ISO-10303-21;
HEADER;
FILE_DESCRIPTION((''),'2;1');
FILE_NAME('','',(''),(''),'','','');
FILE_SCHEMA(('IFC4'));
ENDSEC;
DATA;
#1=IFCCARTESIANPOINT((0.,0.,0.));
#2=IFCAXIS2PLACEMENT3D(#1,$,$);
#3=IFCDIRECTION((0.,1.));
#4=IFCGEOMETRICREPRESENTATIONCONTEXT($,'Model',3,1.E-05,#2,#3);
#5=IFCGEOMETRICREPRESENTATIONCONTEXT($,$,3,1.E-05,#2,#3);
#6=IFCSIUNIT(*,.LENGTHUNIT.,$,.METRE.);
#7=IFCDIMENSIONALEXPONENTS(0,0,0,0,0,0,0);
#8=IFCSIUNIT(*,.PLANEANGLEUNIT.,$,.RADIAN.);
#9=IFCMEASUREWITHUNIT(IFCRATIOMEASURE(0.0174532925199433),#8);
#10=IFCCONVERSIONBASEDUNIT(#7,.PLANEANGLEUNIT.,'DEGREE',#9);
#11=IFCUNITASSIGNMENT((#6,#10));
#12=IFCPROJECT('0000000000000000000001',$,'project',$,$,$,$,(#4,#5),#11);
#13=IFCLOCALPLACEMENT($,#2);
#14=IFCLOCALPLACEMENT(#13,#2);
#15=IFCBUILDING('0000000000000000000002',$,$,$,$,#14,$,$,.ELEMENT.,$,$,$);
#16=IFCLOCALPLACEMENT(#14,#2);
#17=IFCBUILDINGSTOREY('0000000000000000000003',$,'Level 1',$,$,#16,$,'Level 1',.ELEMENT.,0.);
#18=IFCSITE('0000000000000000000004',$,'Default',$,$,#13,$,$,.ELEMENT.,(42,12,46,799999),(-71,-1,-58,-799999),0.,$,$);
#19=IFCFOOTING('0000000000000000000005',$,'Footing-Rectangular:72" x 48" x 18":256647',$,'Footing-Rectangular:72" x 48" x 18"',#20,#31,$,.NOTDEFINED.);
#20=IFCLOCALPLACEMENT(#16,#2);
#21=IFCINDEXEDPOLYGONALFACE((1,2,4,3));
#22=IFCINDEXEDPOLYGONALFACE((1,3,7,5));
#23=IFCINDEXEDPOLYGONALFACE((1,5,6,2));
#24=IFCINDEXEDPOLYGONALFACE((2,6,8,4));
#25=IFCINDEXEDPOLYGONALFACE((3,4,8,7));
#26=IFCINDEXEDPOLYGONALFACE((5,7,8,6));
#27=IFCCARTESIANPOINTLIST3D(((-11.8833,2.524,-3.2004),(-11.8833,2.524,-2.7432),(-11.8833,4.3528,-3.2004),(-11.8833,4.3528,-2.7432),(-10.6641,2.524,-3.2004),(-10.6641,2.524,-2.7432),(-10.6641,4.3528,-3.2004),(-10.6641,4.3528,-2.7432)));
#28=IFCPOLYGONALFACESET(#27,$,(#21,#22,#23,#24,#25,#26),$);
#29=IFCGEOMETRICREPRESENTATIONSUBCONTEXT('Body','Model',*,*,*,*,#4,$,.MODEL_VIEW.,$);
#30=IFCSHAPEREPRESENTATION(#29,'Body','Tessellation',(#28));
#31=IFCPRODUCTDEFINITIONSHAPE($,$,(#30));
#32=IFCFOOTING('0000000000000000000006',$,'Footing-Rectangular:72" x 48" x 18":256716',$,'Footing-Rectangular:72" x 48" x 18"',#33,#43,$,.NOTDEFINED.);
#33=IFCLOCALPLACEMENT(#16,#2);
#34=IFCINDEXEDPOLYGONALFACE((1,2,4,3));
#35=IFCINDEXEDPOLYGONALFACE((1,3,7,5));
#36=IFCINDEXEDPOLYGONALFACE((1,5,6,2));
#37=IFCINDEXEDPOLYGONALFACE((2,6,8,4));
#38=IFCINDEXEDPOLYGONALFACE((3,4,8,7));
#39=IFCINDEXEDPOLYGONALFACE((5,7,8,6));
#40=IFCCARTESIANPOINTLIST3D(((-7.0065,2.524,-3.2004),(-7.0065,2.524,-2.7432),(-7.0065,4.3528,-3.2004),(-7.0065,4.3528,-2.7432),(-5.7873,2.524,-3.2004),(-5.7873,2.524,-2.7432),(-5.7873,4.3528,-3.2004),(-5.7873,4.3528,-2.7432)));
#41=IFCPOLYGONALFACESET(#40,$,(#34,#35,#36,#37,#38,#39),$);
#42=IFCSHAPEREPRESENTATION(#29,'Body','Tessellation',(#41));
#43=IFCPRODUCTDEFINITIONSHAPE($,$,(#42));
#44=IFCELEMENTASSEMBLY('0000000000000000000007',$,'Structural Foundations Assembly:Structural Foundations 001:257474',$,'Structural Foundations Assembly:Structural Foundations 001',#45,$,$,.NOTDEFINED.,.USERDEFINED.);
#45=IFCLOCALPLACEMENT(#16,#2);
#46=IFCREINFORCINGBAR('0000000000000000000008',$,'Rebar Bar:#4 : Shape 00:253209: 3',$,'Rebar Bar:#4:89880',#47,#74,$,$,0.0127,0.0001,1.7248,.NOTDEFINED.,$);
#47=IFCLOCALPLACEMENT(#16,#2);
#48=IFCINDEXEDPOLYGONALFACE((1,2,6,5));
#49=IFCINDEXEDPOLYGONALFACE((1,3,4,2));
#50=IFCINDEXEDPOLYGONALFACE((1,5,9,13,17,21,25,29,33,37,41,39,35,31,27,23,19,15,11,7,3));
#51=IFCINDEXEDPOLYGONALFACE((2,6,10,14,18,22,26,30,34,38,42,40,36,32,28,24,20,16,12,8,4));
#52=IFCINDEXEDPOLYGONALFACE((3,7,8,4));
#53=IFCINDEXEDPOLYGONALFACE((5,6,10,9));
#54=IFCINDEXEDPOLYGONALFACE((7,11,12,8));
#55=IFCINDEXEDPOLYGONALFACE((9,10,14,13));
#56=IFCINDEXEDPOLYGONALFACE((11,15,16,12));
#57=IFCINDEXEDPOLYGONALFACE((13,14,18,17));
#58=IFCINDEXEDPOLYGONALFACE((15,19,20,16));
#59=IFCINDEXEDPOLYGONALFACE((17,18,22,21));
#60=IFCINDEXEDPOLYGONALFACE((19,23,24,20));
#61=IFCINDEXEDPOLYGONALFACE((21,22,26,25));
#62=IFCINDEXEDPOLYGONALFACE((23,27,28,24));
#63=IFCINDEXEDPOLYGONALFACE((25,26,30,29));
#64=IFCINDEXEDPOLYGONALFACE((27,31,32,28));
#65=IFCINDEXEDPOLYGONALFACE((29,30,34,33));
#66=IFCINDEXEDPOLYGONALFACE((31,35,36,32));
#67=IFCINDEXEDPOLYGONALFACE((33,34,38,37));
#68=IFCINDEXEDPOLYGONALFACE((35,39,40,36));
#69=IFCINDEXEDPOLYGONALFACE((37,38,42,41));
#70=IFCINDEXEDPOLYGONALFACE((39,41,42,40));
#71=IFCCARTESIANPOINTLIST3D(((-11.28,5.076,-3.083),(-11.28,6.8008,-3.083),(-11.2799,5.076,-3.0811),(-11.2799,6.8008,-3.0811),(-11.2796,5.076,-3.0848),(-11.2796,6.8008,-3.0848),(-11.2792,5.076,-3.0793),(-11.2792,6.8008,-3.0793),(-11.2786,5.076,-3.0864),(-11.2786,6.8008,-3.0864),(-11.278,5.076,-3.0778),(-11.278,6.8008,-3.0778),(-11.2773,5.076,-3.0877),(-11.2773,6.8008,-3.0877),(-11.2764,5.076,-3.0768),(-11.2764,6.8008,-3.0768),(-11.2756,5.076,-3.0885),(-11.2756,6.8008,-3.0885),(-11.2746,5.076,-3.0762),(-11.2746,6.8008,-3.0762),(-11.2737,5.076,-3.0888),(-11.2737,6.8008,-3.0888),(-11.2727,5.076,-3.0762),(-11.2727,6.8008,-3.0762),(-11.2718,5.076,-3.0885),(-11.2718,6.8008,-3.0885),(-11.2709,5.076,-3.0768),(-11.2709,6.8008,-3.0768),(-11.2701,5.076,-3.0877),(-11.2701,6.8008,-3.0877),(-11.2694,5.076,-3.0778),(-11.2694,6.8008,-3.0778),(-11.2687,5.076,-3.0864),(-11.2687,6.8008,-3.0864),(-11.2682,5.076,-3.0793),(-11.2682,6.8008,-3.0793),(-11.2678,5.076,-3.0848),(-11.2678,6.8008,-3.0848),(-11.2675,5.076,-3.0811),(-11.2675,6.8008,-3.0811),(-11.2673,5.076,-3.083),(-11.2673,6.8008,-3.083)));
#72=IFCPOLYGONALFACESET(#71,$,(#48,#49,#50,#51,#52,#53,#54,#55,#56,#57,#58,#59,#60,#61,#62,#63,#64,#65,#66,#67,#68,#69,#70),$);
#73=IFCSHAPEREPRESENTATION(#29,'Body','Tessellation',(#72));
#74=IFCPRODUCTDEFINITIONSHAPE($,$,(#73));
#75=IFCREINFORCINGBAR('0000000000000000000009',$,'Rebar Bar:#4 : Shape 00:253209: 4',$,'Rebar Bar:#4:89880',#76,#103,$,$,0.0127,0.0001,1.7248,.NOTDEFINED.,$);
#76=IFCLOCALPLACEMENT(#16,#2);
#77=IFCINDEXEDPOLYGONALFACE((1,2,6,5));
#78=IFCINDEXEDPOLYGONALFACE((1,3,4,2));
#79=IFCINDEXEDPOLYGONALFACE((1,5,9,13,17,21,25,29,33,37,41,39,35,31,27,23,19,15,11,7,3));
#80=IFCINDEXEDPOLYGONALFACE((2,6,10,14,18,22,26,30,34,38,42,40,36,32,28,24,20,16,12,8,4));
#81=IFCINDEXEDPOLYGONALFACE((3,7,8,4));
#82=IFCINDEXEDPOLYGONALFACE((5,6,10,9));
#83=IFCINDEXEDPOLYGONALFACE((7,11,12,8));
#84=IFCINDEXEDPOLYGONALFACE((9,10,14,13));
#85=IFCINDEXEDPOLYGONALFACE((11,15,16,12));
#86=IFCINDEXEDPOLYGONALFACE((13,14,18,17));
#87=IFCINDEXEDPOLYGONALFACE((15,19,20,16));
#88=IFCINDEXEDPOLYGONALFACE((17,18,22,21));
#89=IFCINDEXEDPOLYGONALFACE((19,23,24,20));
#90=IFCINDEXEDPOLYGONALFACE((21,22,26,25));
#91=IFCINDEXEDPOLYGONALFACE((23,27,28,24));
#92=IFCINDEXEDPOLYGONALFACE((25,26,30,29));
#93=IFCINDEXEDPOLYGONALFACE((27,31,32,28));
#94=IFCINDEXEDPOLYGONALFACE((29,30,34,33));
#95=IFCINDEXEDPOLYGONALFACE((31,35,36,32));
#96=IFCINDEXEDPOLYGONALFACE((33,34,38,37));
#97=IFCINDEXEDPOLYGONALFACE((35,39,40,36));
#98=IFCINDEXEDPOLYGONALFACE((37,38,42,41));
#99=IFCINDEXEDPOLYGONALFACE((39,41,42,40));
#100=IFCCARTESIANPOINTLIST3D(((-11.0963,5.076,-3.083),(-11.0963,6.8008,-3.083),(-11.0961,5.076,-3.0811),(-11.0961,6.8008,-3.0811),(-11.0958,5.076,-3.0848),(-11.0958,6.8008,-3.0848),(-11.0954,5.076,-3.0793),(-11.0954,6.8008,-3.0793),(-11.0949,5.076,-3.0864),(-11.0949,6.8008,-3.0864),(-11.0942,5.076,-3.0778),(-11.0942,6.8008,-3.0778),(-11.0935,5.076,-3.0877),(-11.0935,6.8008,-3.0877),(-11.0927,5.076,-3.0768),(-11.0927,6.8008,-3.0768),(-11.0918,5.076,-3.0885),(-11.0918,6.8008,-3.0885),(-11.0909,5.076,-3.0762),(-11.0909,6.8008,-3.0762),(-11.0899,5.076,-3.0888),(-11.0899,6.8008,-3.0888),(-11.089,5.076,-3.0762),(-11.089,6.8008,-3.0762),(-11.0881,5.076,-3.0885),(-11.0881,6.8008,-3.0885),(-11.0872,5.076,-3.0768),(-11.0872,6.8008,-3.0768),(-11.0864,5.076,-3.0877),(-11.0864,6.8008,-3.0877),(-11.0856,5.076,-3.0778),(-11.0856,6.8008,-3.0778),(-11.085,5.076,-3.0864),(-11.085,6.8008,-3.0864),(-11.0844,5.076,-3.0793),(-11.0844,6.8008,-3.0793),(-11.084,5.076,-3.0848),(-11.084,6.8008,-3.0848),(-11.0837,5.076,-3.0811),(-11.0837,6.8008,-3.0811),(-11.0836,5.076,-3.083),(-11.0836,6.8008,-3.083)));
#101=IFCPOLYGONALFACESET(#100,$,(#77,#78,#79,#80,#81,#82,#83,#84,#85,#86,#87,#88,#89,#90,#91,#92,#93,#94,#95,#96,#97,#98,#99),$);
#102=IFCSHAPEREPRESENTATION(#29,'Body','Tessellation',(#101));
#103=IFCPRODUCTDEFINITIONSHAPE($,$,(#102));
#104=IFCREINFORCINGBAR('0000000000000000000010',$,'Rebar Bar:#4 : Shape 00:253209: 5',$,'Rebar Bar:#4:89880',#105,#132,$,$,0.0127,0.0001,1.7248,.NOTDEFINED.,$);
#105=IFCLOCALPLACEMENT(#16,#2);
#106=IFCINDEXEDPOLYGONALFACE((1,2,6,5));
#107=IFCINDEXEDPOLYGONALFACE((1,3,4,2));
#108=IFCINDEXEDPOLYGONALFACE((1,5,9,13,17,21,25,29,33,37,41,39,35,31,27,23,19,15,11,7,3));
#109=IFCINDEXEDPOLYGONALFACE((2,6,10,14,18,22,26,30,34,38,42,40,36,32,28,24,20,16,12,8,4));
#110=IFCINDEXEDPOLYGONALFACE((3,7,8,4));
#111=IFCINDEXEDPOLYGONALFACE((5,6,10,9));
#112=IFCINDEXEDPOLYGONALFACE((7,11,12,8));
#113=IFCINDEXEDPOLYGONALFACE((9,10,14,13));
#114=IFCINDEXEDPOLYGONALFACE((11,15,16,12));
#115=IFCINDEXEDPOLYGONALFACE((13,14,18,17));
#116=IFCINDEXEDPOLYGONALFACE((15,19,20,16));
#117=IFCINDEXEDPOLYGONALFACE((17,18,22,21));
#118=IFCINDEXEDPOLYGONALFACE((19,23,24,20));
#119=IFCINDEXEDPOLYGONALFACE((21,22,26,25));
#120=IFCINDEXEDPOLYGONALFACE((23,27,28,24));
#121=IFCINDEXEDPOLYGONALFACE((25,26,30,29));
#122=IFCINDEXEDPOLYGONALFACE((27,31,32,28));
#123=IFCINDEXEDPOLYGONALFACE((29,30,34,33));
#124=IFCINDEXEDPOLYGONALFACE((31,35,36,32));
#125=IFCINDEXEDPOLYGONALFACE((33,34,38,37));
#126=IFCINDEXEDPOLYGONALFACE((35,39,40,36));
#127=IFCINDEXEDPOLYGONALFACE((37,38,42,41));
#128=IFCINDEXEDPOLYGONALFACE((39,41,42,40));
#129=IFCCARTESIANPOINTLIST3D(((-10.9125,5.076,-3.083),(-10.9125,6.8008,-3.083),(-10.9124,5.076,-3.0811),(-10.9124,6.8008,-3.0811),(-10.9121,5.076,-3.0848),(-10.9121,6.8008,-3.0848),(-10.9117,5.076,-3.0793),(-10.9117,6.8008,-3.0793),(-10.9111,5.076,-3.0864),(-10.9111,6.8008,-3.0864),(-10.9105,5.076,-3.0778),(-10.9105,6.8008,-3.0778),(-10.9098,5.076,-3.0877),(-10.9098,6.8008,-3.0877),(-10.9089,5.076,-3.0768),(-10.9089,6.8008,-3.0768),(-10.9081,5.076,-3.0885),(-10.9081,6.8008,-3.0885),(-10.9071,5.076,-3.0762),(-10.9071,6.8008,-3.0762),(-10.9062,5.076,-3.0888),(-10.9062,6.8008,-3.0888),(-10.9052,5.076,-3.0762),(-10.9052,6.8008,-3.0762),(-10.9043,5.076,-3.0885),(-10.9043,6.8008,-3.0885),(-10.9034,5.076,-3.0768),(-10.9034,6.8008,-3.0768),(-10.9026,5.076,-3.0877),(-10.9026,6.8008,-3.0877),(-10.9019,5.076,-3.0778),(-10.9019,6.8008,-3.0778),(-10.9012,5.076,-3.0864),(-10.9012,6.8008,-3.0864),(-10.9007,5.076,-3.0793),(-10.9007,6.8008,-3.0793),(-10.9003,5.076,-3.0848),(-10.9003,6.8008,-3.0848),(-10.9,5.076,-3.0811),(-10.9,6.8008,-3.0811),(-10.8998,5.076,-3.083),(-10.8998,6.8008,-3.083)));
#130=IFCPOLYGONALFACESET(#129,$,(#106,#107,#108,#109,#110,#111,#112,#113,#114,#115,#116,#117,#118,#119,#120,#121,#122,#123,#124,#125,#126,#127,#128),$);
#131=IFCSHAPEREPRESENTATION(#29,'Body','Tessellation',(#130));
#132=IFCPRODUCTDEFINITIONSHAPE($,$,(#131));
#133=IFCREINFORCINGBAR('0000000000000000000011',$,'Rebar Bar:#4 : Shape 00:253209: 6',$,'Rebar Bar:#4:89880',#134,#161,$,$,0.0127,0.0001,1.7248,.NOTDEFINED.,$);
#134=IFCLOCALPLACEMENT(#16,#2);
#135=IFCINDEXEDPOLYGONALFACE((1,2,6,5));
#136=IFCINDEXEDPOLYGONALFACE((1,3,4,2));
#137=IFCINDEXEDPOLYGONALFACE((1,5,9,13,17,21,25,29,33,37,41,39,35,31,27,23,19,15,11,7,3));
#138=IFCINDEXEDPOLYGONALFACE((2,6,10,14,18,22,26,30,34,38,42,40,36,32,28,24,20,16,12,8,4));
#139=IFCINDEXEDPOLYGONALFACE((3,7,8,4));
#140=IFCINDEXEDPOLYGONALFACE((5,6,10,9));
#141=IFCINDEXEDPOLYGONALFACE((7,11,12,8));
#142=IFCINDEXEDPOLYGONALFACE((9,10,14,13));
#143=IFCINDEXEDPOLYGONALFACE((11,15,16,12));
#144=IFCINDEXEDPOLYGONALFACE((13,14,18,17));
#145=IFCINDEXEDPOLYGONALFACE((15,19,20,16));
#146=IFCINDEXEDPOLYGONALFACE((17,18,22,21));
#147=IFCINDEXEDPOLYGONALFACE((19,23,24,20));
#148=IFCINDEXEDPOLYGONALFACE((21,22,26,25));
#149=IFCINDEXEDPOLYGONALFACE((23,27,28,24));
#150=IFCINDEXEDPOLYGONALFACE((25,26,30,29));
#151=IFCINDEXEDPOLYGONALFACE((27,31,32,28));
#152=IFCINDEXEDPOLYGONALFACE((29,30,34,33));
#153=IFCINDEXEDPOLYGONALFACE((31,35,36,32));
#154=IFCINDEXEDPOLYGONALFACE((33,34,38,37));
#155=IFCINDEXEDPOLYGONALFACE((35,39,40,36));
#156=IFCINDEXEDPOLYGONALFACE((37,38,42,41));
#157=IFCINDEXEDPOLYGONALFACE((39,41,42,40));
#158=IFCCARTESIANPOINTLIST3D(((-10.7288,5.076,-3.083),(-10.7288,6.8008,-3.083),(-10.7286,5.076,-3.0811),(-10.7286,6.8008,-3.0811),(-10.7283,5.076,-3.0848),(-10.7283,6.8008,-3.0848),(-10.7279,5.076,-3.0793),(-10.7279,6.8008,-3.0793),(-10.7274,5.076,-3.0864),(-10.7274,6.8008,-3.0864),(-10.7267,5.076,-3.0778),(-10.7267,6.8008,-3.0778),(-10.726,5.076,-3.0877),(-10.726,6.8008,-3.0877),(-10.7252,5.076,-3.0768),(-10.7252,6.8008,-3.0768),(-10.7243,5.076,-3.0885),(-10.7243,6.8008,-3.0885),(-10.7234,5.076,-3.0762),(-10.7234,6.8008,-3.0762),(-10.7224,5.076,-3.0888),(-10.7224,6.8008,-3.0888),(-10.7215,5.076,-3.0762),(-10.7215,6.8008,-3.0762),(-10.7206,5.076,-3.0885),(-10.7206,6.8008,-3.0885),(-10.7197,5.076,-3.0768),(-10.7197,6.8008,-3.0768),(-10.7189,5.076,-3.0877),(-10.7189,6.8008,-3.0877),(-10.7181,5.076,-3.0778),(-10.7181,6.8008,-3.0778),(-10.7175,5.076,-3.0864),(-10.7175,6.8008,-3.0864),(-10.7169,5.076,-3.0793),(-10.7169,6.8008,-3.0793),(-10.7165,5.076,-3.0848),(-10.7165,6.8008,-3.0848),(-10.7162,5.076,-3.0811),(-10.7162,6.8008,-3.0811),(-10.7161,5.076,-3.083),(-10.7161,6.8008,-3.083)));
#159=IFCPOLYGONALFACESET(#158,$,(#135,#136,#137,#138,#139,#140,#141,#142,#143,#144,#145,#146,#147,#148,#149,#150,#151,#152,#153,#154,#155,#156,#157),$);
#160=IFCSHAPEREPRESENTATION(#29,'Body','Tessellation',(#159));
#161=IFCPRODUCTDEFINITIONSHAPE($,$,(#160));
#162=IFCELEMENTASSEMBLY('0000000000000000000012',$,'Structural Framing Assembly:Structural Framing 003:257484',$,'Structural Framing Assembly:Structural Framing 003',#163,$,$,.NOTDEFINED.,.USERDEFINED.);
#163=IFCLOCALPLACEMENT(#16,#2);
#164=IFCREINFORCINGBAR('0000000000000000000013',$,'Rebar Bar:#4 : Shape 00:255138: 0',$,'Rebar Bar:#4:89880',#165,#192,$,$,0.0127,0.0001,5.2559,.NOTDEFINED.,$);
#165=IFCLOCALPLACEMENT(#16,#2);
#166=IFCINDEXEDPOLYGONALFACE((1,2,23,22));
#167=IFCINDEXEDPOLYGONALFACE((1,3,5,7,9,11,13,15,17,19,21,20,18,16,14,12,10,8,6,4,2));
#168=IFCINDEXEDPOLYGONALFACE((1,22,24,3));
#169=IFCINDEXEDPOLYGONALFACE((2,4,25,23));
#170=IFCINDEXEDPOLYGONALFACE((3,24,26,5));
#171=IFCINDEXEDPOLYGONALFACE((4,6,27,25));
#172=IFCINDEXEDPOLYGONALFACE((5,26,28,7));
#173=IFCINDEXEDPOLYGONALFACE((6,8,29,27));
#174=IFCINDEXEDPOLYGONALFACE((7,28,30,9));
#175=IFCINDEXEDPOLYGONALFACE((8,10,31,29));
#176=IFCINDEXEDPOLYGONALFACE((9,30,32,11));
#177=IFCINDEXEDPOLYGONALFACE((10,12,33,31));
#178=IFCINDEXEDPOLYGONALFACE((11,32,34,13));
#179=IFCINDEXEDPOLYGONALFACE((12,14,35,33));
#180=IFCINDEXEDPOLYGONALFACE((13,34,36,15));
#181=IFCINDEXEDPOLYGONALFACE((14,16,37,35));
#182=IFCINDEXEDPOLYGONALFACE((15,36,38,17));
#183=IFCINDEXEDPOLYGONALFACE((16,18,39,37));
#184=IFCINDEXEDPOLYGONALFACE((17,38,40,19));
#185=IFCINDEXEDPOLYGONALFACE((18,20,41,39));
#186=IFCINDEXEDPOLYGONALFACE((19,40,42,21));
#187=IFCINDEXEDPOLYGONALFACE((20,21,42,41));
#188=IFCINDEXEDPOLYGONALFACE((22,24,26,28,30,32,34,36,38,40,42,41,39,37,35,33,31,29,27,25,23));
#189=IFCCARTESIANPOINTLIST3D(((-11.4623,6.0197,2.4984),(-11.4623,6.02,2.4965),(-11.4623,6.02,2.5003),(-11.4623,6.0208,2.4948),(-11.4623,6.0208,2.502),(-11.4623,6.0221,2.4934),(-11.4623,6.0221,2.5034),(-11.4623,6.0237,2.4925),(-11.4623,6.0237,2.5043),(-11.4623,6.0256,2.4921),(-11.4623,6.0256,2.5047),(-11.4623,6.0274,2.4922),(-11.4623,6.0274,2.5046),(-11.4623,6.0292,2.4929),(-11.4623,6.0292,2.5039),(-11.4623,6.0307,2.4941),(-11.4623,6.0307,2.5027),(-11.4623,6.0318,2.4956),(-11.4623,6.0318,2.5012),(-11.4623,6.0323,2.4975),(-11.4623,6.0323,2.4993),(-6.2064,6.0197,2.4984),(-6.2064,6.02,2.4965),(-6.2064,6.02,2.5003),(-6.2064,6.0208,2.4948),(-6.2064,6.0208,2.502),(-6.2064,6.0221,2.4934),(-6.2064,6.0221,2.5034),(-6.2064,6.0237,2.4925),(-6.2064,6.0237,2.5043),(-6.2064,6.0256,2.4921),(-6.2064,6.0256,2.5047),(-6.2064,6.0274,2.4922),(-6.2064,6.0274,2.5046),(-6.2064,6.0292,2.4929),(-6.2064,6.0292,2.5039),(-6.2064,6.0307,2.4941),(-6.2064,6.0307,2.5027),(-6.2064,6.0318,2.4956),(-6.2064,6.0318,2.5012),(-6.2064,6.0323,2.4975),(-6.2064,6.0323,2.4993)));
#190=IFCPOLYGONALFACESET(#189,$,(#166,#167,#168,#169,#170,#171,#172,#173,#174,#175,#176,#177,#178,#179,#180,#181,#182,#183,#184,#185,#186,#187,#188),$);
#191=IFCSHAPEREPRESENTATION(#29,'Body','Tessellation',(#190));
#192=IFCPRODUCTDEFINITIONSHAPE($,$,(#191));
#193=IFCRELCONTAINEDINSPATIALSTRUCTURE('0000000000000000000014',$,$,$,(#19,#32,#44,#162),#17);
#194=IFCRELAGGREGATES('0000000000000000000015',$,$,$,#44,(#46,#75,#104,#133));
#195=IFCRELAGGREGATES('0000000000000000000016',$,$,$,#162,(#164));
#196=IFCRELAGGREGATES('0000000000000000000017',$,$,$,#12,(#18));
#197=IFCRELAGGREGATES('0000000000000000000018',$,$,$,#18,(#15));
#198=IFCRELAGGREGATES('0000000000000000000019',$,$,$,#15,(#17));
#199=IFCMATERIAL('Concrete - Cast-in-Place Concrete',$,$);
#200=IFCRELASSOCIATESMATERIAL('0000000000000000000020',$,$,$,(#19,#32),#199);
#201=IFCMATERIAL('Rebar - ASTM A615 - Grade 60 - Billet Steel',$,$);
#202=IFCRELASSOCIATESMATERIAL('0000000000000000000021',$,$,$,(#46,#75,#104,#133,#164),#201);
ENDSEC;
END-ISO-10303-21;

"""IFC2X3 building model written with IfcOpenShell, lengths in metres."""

from ifc_helpers import new_model, entity, si_unit, converted_unit, direction, frame, frame_2d, origin, origin_2d_with_axis, place, context, subcontext, project, spatial, rectangle, extrude, material, element, aggregate, save


model = new_model("IFC2X3")

# Units and contexts
model_context = context("Model", 3, precision=1e-05, world=origin(), true_north=direction((0.0, 1.0)))
context_of_model = context(None, 3, precision=1e-05, world=origin(), true_north=direction((0.0, 1.0)))
body_context = subcontext(model_context, "Body", "Model", "MODEL_VIEW")
ifc_project = project(units=[si_unit("LENGTHUNIT", "METRE"), converted_unit("PLANEANGLEUNIT", "DEGREE", entity("IfcRatioMeasure", 0.0174532925199433), si_unit("PLANEANGLEUNIT", "RADIAN"), dimensions=[0, 0, 0, 0, 0, 0, 0])], contexts=[model_context, context_of_model])

# Site, building, storey
site_placement = place(None, origin())
site = spatial("IfcSite", under=ifc_project, at=site_placement, Name="Default", CompositionType="ELEMENT", RefLatitude=(42, 12, 46, 799999), RefLongitude=(-71, -1, -58, -799999), RefElevation=0.0)
building_placement = place(site_placement, origin())
building = spatial("IfcBuilding", under=site, at=building_placement, CompositionType="ELEMENT")
storey_placement = place(building_placement, origin())
storey = spatial("IfcBuildingStorey", under=building, at=storey_placement, Name="Level 1", LongName="Level 1", CompositionType="ELEMENT", Elevation=0.0)

# Footings
ifc_material_1 = material(Name="Concrete - Cast-in-Place Concrete")
footing_1_placement = place(storey_placement, origin())
element("IfcFooting", 1, at=footing_1_placement, inside=storey, material=ifc_material_1, Name="Footing-Rectangular:72\" x 48\" x 18\":256647", ObjectType="Footing-Rectangular:72\" x 48\" x 18\"", PredefinedType="NOTDEFINED", context=body_context, shape_type="SweptSolid", body=[
    extrude(rectangle(XDim=1.2192, YDim=1.8288, at=origin_2d_with_axis()), frame((-11.2737, 3.4384, -3.2004), z_axis=(0.0, 0.0, 1.0), x_axis=(-1.0, 0.0, 0.0)), (0.0, 0.0, 1.0), 0.4572),
])
footing_2_placement = place(storey_placement, origin())
element("IfcFooting", 2, at=footing_2_placement, inside=storey, material=ifc_material_1, Name="Footing-Rectangular:72\" x 48\" x 18\":256716", ObjectType="Footing-Rectangular:72\" x 48\" x 18\"", PredefinedType="NOTDEFINED", context=body_context, shape_type="SweptSolid", body=[
    extrude(rectangle(XDim=1.2192, YDim=1.8288, at=frame_2d((0.0, 0.0), x_axis=(1.0, 0.0))), frame((-6.3969, 3.4384, -3.2004), z_axis=(0.0, 0.0, 1.0), x_axis=(-1.0, 0.0, 0.0)), (0.0, 0.0, 1.0), 0.4572),
])

# Element assemblies, reinforcing bars
assembly_1_placement = place(storey_placement, origin())
assembly_1 = element("IfcElementAssembly", 3, at=assembly_1_placement, inside=storey, Name="Structural Foundations Assembly:Structural Foundations 001:257474", ObjectType="Structural Foundations Assembly:Structural Foundations 001", AssemblyPlace="NOTDEFINED", PredefinedType="USERDEFINED")
ifc_material_2 = material(Name="Rebar - ASTM A615 - Grade 60 - Billet Steel")
reinforcing_bar_1_placement = place(assembly_1_placement, origin())
reinforcing_bar_1 = element("IfcReinforcingBar", 4, at=reinforcing_bar_1_placement, material=ifc_material_2, Name="Rebar Bar:#4 : Shape 00:253209: 3", ObjectType="Rebar Bar:#4:89880", BarLength=1.7248, BarRole="NOTDEFINED", CrossSectionArea=0.0001, NominalDiameter=0.0127, context=body_context, shape_type="AdvancedSweptSolid", body=[
    entity("IfcSweptDiskSolid", entity("IfcCompositeCurve", [entity("IfcCompositeCurveSegment", "CONTINUOUS", True, entity("IfcPolyline", [entity("IfcCartesianPoint", [-11.2737, 6.8008, -3.0825]), entity("IfcCartesianPoint", [-11.2737, 5.076, -3.0825])]))], False), 0.0063, None, 0.0, 1.0),
])
reinforcing_bar_2_placement = place(assembly_1_placement, origin())
reinforcing_bar_2 = element("IfcReinforcingBar", 5, at=reinforcing_bar_2_placement, material=ifc_material_2, Name="Rebar Bar:#4 : Shape 00:253209: 4", ObjectType="Rebar Bar:#4:89880", BarLength=1.7248, BarRole="NOTDEFINED", CrossSectionArea=0.0001, NominalDiameter=0.0127, context=body_context, shape_type="AdvancedSweptSolid", body=[
    entity("IfcSweptDiskSolid", entity("IfcCompositeCurve", [entity("IfcCompositeCurveSegment", "CONTINUOUS", True, entity("IfcPolyline", [entity("IfcCartesianPoint", [-11.0899, 6.8008, -3.0825]), entity("IfcCartesianPoint", [-11.0899, 5.076, -3.0825])]))], False), 0.0063, None, 0.0, 1.0),
])
reinforcing_bar_3_placement = place(assembly_1_placement, origin())
reinforcing_bar_3 = element("IfcReinforcingBar", 6, at=reinforcing_bar_3_placement, material=ifc_material_2, Name="Rebar Bar:#4 : Shape 00:253209: 5", ObjectType="Rebar Bar:#4:89880", BarLength=1.7248, BarRole="NOTDEFINED", CrossSectionArea=0.0001, NominalDiameter=0.0127, context=body_context, shape_type="AdvancedSweptSolid", body=[
    entity("IfcSweptDiskSolid", entity("IfcCompositeCurve", [entity("IfcCompositeCurveSegment", "CONTINUOUS", True, entity("IfcPolyline", [entity("IfcCartesianPoint", [-10.9062, 6.8008, -3.0825]), entity("IfcCartesianPoint", [-10.9062, 5.076, -3.0825])]))], False), 0.0063, None, 0.0, 1.0),
])
reinforcing_bar_4_placement = place(assembly_1_placement, origin())
reinforcing_bar_4 = element("IfcReinforcingBar", 7, at=reinforcing_bar_4_placement, material=ifc_material_2, Name="Rebar Bar:#4 : Shape 00:253209: 6", ObjectType="Rebar Bar:#4:89880", BarLength=1.7248, BarRole="NOTDEFINED", CrossSectionArea=0.0001, NominalDiameter=0.0127, context=body_context, shape_type="AdvancedSweptSolid", body=[
    entity("IfcSweptDiskSolid", entity("IfcCompositeCurve", [entity("IfcCompositeCurveSegment", "CONTINUOUS", True, entity("IfcPolyline", [entity("IfcCartesianPoint", [-10.7224, 6.8008, -3.0825]), entity("IfcCartesianPoint", [-10.7224, 5.076, -3.0825])]))], False), 0.0063, None, 0.0, 1.0),
])
aggregate(assembly_1, [reinforcing_bar_1, reinforcing_bar_2, reinforcing_bar_3, reinforcing_bar_4])
assembly_2_placement = place(storey_placement, origin())
assembly_2 = element("IfcElementAssembly", 8, at=assembly_2_placement, inside=storey, Name="Structural Framing Assembly:Structural Framing 003:257484", ObjectType="Structural Framing Assembly:Structural Framing 003", AssemblyPlace="NOTDEFINED", PredefinedType="USERDEFINED")
reinforcing_bar_5_placement = place(assembly_2_placement, origin())
reinforcing_bar_5 = element("IfcReinforcingBar", 9, at=reinforcing_bar_5_placement, material=ifc_material_2, Name="Rebar Bar:#4 : Shape 00:255138: 0", ObjectType="Rebar Bar:#4:89880", BarLength=5.2559, BarRole="NOTDEFINED", CrossSectionArea=0.0001, NominalDiameter=0.0127, context=body_context, shape_type="AdvancedSweptSolid", body=[
    entity("IfcSweptDiskSolid", entity("IfcCompositeCurve", [entity("IfcCompositeCurveSegment", "CONTINUOUS", True, entity("IfcPolyline", [entity("IfcCartesianPoint", [-6.2064, 6.026, 2.4984]), entity("IfcCartesianPoint", [-11.4623, 6.026, 2.4984])]))], False), 0.0063, None, 0.0, 1.0),
])
aggregate(assembly_2, [reinforcing_bar_5])

save(model, "model.ifc")
